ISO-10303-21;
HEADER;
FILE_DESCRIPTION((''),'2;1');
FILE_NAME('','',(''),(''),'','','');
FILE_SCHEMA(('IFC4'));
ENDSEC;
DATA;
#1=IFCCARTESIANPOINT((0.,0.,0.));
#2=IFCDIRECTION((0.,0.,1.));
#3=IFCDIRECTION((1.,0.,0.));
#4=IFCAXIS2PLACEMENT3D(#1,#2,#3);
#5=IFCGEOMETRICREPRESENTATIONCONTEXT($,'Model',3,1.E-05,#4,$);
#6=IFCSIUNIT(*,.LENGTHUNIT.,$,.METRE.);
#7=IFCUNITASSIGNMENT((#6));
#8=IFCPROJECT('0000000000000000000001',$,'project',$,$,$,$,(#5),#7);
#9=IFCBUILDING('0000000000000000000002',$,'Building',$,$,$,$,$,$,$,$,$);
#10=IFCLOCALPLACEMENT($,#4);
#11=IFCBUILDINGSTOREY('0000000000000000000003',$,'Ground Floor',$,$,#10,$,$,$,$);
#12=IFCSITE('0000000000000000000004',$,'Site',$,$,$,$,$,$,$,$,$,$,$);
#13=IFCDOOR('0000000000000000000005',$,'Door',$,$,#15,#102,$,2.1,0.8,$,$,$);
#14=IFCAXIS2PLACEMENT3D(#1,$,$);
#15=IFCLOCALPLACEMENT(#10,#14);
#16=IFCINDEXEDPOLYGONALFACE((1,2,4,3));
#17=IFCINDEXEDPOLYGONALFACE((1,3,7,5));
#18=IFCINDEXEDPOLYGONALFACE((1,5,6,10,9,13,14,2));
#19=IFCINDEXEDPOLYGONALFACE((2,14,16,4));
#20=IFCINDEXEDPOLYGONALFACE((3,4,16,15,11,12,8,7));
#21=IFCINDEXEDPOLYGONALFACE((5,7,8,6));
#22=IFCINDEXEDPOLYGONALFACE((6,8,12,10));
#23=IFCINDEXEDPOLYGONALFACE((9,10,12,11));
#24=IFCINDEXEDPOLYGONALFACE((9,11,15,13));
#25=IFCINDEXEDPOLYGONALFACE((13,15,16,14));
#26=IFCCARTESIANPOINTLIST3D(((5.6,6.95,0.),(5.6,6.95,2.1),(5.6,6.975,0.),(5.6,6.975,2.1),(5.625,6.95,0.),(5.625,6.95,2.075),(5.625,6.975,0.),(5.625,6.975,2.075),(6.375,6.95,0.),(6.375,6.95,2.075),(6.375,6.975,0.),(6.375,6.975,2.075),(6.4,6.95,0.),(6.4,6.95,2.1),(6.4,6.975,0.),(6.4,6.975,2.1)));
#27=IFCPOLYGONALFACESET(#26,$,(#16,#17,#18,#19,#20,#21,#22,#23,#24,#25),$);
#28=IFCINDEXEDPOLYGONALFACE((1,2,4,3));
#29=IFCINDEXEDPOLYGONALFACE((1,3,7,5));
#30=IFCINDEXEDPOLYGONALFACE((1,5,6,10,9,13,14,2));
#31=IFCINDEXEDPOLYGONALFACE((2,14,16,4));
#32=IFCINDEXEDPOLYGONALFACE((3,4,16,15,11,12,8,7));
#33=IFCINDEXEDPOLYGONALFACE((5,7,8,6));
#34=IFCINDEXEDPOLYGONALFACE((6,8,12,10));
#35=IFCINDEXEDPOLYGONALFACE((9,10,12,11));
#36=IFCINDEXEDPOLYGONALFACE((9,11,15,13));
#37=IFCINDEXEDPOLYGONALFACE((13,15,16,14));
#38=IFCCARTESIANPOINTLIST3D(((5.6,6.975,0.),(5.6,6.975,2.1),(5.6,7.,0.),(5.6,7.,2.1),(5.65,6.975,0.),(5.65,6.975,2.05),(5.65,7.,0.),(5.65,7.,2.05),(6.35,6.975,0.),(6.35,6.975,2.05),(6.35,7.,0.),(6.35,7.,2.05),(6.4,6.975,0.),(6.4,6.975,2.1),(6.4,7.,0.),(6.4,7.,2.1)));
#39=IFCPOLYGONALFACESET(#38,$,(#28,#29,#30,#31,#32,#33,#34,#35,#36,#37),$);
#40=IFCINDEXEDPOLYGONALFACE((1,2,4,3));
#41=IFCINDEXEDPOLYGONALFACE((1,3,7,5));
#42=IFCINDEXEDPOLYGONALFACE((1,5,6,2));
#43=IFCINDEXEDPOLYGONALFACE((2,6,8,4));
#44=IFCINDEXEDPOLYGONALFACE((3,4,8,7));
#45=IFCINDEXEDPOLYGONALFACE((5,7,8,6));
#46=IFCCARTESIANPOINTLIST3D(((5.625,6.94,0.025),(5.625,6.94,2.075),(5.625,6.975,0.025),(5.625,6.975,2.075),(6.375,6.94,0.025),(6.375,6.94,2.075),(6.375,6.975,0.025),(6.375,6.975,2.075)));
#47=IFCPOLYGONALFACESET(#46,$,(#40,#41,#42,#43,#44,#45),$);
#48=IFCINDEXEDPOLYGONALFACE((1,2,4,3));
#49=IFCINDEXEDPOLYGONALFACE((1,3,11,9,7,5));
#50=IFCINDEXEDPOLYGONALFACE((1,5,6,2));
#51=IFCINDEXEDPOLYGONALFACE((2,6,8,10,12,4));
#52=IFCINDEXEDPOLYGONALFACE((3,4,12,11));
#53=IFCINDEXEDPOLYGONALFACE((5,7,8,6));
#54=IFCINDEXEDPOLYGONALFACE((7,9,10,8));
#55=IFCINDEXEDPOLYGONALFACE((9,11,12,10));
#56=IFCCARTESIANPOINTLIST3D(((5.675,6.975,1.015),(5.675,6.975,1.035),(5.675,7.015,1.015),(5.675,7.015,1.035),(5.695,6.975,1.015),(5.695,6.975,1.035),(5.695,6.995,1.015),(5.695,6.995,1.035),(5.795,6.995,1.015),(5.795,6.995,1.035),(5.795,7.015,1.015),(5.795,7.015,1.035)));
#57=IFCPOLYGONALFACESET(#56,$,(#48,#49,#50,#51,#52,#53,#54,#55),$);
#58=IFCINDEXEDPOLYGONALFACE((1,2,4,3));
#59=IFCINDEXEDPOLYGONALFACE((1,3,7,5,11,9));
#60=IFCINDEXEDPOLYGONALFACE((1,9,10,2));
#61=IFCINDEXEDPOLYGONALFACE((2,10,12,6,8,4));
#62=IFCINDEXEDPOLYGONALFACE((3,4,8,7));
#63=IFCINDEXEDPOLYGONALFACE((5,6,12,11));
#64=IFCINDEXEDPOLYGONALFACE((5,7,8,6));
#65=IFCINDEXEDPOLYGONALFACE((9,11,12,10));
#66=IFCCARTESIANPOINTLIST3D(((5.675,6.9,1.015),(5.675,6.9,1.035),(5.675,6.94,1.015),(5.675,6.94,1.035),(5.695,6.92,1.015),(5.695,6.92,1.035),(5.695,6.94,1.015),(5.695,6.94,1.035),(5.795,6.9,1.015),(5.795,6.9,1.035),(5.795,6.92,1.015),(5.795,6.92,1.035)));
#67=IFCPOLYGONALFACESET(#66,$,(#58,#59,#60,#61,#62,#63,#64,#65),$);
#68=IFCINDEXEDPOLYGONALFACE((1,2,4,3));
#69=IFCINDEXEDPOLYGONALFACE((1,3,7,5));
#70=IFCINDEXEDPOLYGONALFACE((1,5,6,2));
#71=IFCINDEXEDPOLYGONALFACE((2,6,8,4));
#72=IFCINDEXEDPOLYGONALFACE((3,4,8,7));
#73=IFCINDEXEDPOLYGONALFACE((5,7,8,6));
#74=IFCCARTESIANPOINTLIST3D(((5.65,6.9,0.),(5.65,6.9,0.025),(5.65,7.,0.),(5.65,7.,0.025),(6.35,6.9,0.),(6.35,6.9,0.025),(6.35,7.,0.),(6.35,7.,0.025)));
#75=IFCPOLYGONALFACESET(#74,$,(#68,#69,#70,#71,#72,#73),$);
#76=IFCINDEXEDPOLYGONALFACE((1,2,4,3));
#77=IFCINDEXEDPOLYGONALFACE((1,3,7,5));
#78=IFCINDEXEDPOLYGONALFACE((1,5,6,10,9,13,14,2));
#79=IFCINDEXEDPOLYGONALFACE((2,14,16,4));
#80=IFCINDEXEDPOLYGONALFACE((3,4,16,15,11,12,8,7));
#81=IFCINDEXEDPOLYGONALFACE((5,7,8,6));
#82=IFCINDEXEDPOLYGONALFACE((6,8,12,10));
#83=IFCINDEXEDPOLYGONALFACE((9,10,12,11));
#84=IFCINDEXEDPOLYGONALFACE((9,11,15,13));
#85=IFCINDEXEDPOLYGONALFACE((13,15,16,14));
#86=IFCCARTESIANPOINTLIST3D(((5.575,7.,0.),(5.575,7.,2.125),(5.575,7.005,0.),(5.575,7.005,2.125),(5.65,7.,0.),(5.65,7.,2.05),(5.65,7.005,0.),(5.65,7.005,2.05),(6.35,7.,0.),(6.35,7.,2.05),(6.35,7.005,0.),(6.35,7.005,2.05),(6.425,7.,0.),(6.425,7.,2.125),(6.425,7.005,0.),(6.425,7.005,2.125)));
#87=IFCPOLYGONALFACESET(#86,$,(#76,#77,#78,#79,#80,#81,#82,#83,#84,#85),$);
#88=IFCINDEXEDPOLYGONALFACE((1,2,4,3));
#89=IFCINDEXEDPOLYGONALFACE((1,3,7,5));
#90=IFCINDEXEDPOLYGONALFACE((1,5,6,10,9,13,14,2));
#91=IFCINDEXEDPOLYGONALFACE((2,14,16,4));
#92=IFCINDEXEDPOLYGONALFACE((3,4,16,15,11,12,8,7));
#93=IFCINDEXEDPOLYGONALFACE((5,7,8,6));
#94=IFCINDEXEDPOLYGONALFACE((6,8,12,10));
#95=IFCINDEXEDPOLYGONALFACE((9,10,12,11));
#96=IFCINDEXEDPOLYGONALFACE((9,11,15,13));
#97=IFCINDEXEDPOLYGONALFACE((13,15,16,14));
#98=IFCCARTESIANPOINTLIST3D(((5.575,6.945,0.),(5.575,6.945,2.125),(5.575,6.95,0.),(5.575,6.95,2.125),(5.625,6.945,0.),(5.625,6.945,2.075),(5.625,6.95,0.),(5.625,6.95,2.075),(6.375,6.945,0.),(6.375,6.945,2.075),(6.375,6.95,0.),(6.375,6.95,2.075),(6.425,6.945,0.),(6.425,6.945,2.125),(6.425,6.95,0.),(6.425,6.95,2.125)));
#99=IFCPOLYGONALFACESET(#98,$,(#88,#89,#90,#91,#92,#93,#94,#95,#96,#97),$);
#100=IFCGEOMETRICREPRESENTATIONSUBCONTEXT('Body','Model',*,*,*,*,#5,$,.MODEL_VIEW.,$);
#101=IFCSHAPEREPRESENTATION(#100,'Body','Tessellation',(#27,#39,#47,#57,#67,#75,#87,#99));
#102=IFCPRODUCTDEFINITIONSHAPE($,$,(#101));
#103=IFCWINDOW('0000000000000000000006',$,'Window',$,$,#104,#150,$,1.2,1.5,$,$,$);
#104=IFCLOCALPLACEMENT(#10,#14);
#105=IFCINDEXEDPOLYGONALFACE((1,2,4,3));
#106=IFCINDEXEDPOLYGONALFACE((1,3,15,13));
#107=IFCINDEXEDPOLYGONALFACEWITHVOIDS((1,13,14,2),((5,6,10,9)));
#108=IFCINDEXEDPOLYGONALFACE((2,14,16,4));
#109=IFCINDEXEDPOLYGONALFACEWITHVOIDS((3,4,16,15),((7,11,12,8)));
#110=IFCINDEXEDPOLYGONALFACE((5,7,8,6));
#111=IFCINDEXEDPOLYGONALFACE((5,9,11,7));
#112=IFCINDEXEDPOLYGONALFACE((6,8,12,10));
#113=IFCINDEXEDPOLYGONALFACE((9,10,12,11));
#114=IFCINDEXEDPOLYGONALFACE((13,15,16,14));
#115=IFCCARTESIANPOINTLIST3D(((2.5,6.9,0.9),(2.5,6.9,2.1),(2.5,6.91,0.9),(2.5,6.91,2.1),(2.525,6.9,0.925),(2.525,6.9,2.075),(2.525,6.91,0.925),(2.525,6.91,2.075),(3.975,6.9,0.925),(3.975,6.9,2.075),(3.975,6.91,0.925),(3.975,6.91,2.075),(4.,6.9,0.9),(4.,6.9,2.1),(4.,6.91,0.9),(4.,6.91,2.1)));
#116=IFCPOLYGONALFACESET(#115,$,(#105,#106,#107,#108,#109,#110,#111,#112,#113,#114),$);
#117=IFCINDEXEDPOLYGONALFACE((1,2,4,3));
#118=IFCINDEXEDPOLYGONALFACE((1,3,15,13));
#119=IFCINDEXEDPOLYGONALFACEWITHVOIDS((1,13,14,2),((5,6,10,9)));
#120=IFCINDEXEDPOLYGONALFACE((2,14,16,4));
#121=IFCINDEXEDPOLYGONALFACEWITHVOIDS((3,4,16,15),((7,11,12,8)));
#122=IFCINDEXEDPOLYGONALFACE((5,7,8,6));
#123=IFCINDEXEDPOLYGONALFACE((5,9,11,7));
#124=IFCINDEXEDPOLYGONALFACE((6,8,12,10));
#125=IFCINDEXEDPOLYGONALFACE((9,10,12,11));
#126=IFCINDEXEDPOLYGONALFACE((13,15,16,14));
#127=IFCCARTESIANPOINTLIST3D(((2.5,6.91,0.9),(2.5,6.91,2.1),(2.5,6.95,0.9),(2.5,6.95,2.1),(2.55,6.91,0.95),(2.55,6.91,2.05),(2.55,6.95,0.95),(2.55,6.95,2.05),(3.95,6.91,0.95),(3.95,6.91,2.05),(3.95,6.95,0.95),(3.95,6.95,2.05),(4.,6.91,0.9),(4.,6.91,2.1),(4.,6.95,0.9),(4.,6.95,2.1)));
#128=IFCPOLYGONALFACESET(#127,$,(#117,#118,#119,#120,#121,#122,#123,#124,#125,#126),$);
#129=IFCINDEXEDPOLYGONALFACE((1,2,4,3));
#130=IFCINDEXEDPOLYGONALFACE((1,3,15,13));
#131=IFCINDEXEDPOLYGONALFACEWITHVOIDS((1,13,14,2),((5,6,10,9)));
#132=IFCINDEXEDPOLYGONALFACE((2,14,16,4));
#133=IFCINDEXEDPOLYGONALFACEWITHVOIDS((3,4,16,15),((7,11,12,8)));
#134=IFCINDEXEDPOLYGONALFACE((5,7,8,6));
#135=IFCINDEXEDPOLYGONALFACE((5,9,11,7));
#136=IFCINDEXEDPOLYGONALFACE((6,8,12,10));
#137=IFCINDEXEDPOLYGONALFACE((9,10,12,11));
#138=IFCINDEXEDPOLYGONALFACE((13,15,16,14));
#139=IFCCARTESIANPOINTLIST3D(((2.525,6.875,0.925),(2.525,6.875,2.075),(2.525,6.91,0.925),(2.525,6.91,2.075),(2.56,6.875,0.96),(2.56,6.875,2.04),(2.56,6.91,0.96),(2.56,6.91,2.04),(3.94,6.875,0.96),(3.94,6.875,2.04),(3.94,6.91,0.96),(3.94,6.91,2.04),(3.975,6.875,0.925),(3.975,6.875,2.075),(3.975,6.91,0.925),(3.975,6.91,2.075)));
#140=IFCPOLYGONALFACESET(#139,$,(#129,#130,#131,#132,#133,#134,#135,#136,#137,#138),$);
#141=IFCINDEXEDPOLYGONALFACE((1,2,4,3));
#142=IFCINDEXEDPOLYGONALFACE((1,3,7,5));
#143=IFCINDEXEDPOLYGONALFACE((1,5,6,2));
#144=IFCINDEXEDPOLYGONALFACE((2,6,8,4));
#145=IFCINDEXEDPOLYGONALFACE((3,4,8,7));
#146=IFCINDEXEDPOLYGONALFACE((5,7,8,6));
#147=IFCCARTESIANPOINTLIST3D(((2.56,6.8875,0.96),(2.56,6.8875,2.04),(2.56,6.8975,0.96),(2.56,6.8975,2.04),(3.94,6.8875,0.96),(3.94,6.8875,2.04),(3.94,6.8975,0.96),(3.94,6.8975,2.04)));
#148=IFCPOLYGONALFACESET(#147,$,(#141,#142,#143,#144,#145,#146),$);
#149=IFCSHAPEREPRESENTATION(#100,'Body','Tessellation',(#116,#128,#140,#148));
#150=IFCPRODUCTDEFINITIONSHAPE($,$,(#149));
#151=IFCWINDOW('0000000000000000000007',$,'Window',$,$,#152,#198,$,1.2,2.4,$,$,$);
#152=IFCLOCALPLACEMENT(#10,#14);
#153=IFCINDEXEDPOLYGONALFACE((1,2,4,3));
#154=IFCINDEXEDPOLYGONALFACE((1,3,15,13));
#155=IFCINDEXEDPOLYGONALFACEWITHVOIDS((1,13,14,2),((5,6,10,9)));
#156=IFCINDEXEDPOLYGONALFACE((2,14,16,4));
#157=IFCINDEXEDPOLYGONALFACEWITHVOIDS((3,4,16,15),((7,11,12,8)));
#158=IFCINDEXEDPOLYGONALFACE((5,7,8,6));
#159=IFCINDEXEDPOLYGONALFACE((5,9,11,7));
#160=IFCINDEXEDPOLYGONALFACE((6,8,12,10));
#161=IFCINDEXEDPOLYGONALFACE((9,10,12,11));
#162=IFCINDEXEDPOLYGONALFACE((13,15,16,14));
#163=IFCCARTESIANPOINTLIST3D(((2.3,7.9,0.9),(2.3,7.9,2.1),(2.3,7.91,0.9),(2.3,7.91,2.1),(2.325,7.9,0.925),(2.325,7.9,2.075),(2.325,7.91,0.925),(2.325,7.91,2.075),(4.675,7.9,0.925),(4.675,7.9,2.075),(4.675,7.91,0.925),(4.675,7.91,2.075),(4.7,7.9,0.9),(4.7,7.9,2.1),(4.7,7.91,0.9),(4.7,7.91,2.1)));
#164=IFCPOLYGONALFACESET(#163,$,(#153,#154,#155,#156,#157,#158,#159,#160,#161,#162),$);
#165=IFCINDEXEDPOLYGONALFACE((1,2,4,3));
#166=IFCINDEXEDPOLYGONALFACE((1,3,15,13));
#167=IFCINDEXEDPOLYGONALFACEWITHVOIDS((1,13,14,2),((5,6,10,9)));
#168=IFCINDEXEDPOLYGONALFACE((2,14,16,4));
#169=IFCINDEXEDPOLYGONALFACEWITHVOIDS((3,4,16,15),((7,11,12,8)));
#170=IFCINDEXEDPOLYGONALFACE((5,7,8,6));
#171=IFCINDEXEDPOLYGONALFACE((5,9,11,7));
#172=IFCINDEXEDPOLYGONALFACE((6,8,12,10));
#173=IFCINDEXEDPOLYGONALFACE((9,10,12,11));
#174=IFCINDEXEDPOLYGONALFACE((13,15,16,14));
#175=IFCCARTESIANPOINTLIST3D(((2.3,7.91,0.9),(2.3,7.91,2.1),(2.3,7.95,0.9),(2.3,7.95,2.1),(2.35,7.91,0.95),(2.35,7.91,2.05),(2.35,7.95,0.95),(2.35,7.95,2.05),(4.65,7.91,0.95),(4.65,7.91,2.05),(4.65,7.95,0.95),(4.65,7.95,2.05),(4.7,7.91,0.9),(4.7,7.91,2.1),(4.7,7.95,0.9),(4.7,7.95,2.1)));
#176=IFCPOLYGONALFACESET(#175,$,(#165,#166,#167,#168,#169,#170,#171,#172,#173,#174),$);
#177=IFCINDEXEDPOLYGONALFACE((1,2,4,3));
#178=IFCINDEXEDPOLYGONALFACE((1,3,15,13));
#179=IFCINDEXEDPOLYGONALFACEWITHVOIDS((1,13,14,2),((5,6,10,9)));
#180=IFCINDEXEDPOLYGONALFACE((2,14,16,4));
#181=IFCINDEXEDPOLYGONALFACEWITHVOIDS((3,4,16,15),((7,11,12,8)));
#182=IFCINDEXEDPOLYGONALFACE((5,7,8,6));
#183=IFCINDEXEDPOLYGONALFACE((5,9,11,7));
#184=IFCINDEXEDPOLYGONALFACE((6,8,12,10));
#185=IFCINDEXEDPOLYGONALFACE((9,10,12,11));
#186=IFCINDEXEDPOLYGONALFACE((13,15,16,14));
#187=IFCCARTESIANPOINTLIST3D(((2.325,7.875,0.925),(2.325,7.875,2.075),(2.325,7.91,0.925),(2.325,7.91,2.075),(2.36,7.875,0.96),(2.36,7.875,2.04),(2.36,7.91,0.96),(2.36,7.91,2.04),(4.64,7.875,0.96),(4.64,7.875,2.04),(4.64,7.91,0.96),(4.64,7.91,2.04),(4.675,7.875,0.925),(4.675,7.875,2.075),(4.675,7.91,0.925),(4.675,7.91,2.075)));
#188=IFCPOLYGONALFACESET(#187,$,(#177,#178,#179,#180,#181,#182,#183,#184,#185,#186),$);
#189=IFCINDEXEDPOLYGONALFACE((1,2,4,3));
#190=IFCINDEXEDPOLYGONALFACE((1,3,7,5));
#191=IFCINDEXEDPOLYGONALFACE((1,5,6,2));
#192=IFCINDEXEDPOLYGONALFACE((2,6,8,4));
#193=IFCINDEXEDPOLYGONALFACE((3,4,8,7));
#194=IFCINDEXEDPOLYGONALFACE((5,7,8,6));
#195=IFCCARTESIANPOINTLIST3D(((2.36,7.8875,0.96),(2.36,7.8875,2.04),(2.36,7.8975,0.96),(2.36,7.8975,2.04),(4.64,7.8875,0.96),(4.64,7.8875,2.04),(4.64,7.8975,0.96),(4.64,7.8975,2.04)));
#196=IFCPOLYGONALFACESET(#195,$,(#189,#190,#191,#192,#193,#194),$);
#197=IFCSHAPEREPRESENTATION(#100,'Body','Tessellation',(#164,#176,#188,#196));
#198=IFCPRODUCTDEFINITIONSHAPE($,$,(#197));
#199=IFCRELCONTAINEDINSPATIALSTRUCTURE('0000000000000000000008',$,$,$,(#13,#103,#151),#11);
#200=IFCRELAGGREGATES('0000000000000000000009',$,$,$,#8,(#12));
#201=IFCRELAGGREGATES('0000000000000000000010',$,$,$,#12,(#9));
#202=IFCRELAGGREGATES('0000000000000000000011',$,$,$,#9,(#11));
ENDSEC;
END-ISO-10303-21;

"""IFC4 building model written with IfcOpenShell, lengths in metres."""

from ifc_helpers import new_model, si_unit, frame, origin_with_axes, place, context, subcontext, project, spatial, line, indexed_curve, outline, extrude, element, save


model = new_model("IFC4")

# Units and contexts
model_context = context("Model", 3, precision=1e-05, world=origin_with_axes())
body_context = subcontext(model_context, "Body", "Model", "MODEL_VIEW")
ifc_project = project(units=[si_unit("LENGTHUNIT", "METRE")], contexts=[model_context])

# Site, building, storey
site = spatial("IfcSite", under=ifc_project, Name="Site")
building = spatial("IfcBuilding", under=site, Name="Building")
storey_placement = place(None, origin_with_axes())
storey = spatial("IfcBuildingStorey", under=building, at=storey_placement, Name="Ground Floor")

# Door
door_1_placement = place(storey_placement, frame((6.4, 7.0, 0.0), z_axis=(0.0, 0.0, 1.0), x_axis=(-1.0, 0.0, 0.0)))
element("IfcDoor", 1, at=door_1_placement, inside=storey, Name="Door", OverallHeight=2.1, OverallWidth=0.8, context=body_context, shape_type="SweptSolid", body=[
    extrude(outline(indexed_curve([(0.0, 0.0), (0.0, 2.1), (0.8, 2.1), (0.8, 0.0), (0.775, 0.0), (0.775, 2.075), (0.025, 2.075), (0.025, 0.0)], segments=[line(1, 2, 3, 4, 5, 6, 7, 8, 1)])), frame((0.0, 0.025, 0.0), z_axis=(0.0, -1.0, 0.0), x_axis=(1.0, 0.0, 0.0)), (0.0, 0.0, -1.0), 0.025),
    extrude(outline(indexed_curve([(0.0, 0.0), (0.0, 2.1), (0.8, 2.1), (0.8, 0.0), (0.75, 0.0), (0.75, 2.05), (0.05, 2.05), (0.05, 0.0)], segments=[line(1, 2, 3, 4, 5, 6, 7, 8, 1)])), frame((0.0, 0.0, 0.0), z_axis=(0.0, -1.0, 0.0), x_axis=(1.0, 0.0, 0.0)), (0.0, 0.0, -1.0), 0.025),
    extrude(outline(indexed_curve([(0.0, 0.0), (0.75, 0.0), (0.75, 0.035), (0.0, 0.035)], segments=[line(1, 2, 3, 4, 1)])), frame((0.025, 0.025, 0.025), z_axis=(0.0, 0.0, 1.0), x_axis=(1.0, 0.0, 0.0)), (0.0, 0.0, 1.0), 2.05),
    extrude(outline(indexed_curve([(0.0, 0.0), (0.0, -0.04), (-0.12, -0.04), (-0.12, -0.02), (-0.02, -0.02), (-0.02, 0.0)], segments=[line(1, 2, 3, 4, 5, 6, 1)])), frame((0.725, 0.025, 1.015), z_axis=(0.0, 0.0, 1.0), x_axis=(1.0, 0.0, 0.0)), (0.0, 0.0, 1.0), 0.02),
    extrude(outline(indexed_curve([(0.0, 0.0), (0.0, 0.04), (-0.12, 0.04), (-0.12, 0.02), (-0.02, 0.02), (-0.02, 0.0)], segments=[line(1, 2, 3, 4, 5, 6, 1)])), frame((0.725, 0.06, 1.015), z_axis=(0.0, 0.0, 1.0), x_axis=(1.0, 0.0, 0.0)), (0.0, 0.0, 1.0), 0.02),
    extrude(outline(indexed_curve([(0.0, 0.0), (0.7, 0.0), (0.7, 0.1), (0.0, 0.1)], segments=[line(1, 2, 3, 4, 1)])), frame((0.05, 0.0, 0.0), z_axis=(0.0, 0.0, 1.0), x_axis=(1.0, 0.0, 0.0)), (0.0, 0.0, 1.0), 0.025),
    extrude(outline(indexed_curve([(0.0, 0.0), (0.0, 2.125), (0.85, 2.125), (0.85, 0.0), (0.775, 0.0), (0.775, 2.05), (0.075, 2.05), (0.075, 0.0)], segments=[line(1, 2, 3, 4, 5, 6, 7, 8, 1)])), frame((-0.025, -0.005, 0.0), z_axis=(0.0, -1.0, 0.0), x_axis=(1.0, 0.0, 0.0)), (0.0, 0.0, -1.0), 0.005),
    extrude(outline(indexed_curve([(0.0, 0.0), (0.0, 2.125), (0.85, 2.125), (0.85, 0.0), (0.8, 0.0), (0.8, 2.075), (0.05, 2.075), (0.05, 0.0)], segments=[line(1, 2, 3, 4, 5, 6, 7, 8, 1)])), frame((-0.025, 0.05, 0.0), z_axis=(0.0, -1.0, 0.0), x_axis=(1.0, 0.0, 0.0)), (0.0, 0.0, -1.0), 0.005),
])

# Windows
window_1_placement = place(storey_placement, frame((4.0, 7.0, 0.9), z_axis=(0.0, 0.0, 1.0), x_axis=(-1.0, 0.0, 0.0)))
element("IfcWindow", 2, at=window_1_placement, inside=storey, Name="Window", OverallHeight=1.2, OverallWidth=1.5, context=body_context, shape_type="SweptSolid", body=[
    extrude(outline(indexed_curve([(0.0, 0.0), (1.5, 0.0), (1.5, 1.2), (0.0, 1.2)], segments=[line(1, 2, 3, 4, 1)]), holes=[indexed_curve([(0.025, 0.025), (1.475, 0.025), (1.475, 1.175), (0.025, 1.175)], segments=[line(1, 2, 3, 4, 1)])]), frame((0.0, 0.09, 0.0), z_axis=(0.0, -1.0, 0.0), x_axis=(1.0, 0.0, 0.0)), (0.0, 0.0, -1.0), 0.01),
    extrude(outline(indexed_curve([(0.0, 0.0), (1.5, 0.0), (1.5, 1.2), (0.0, 1.2)], segments=[line(1, 2, 3, 4, 1)]), holes=[indexed_curve([(0.05, 0.05), (1.45, 0.05), (1.45, 1.15), (0.05, 1.15)], segments=[line(1, 2, 3, 4, 1)])]), frame((0.0, 0.05, 0.0), z_axis=(0.0, -1.0, 0.0), x_axis=(1.0, 0.0, 0.0)), (0.0, 0.0, -1.0), 0.04),
    extrude(outline(indexed_curve([(0.0, 0.0), (1.45, 0.0), (1.45, 1.15), (0.0, 1.15)], segments=[line(1, 2, 3, 4, 1)]), holes=[indexed_curve([(0.035, 0.035), (1.415, 0.035), (1.415, 1.115), (0.035, 1.115)], segments=[line(1, 2, 3, 4, 1)])]), frame((0.025, 0.09, 0.025), z_axis=(0.0, -1.0, 0.0), x_axis=(1.0, 0.0, 0.0)), (0.0, 0.0, -1.0), 0.035),
    extrude(outline(indexed_curve([(0.035, 0.035), (1.415, 0.035), (1.415, 1.115), (0.035, 1.115)], segments=[line(1, 2, 3, 4, 1)])), frame((0.025, 0.1025, 0.025), z_axis=(0.0, -1.0, 0.0), x_axis=(1.0, 0.0, 0.0)), (0.0, 0.0, -1.0), 0.01),
])
window_2_placement = place(storey_placement, frame((4.7, 8.0, 0.9), z_axis=(0.0, 0.0, 1.0), x_axis=(-1.0, 0.0, 0.0)))
element("IfcWindow", 3, at=window_2_placement, inside=storey, Name="Window", OverallHeight=1.2, OverallWidth=2.4, context=body_context, shape_type="SweptSolid", body=[
    extrude(outline(indexed_curve([(0.0, 0.0), (2.4, 0.0), (2.4, 1.2), (0.0, 1.2)], segments=[line(1, 2, 3, 4, 1)]), holes=[indexed_curve([(0.025, 0.025), (2.375, 0.025), (2.375, 1.175), (0.025, 1.175)], segments=[line(1, 2, 3, 4, 1)])]), frame((0.0, 0.09, 0.0), z_axis=(0.0, -1.0, 0.0), x_axis=(1.0, 0.0, 0.0)), (0.0, 0.0, -1.0), 0.01),
    extrude(outline(indexed_curve([(0.0, 0.0), (2.4, 0.0), (2.4, 1.2), (0.0, 1.2)], segments=[line(1, 2, 3, 4, 1)]), holes=[indexed_curve([(0.05, 0.05), (2.35, 0.05), (2.35, 1.15), (0.05, 1.15)], segments=[line(1, 2, 3, 4, 1)])]), frame((0.0, 0.05, 0.0), z_axis=(0.0, -1.0, 0.0), x_axis=(1.0, 0.0, 0.0)), (0.0, 0.0, -1.0), 0.04),
    extrude(outline(indexed_curve([(0.0, 0.0), (2.35, 0.0), (2.35, 1.15), (0.0, 1.15)], segments=[line(1, 2, 3, 4, 1)]), holes=[indexed_curve([(0.035, 0.035), (2.315, 0.035), (2.315, 1.115), (0.035, 1.115)], segments=[line(1, 2, 3, 4, 1)])]), frame((0.025, 0.09, 0.025), z_axis=(0.0, -1.0, 0.0), x_axis=(1.0, 0.0, 0.0)), (0.0, 0.0, -1.0), 0.035),
    extrude(outline(indexed_curve([(0.035, 0.035), (2.315, 0.035), (2.315, 1.115), (0.035, 1.115)], segments=[line(1, 2, 3, 4, 1)])), frame((0.025, 0.1025, 0.025), z_axis=(0.0, -1.0, 0.0), x_axis=(1.0, 0.0, 0.0)), (0.0, 0.0, -1.0), 0.01),
])

save(model, "model.ifc")
